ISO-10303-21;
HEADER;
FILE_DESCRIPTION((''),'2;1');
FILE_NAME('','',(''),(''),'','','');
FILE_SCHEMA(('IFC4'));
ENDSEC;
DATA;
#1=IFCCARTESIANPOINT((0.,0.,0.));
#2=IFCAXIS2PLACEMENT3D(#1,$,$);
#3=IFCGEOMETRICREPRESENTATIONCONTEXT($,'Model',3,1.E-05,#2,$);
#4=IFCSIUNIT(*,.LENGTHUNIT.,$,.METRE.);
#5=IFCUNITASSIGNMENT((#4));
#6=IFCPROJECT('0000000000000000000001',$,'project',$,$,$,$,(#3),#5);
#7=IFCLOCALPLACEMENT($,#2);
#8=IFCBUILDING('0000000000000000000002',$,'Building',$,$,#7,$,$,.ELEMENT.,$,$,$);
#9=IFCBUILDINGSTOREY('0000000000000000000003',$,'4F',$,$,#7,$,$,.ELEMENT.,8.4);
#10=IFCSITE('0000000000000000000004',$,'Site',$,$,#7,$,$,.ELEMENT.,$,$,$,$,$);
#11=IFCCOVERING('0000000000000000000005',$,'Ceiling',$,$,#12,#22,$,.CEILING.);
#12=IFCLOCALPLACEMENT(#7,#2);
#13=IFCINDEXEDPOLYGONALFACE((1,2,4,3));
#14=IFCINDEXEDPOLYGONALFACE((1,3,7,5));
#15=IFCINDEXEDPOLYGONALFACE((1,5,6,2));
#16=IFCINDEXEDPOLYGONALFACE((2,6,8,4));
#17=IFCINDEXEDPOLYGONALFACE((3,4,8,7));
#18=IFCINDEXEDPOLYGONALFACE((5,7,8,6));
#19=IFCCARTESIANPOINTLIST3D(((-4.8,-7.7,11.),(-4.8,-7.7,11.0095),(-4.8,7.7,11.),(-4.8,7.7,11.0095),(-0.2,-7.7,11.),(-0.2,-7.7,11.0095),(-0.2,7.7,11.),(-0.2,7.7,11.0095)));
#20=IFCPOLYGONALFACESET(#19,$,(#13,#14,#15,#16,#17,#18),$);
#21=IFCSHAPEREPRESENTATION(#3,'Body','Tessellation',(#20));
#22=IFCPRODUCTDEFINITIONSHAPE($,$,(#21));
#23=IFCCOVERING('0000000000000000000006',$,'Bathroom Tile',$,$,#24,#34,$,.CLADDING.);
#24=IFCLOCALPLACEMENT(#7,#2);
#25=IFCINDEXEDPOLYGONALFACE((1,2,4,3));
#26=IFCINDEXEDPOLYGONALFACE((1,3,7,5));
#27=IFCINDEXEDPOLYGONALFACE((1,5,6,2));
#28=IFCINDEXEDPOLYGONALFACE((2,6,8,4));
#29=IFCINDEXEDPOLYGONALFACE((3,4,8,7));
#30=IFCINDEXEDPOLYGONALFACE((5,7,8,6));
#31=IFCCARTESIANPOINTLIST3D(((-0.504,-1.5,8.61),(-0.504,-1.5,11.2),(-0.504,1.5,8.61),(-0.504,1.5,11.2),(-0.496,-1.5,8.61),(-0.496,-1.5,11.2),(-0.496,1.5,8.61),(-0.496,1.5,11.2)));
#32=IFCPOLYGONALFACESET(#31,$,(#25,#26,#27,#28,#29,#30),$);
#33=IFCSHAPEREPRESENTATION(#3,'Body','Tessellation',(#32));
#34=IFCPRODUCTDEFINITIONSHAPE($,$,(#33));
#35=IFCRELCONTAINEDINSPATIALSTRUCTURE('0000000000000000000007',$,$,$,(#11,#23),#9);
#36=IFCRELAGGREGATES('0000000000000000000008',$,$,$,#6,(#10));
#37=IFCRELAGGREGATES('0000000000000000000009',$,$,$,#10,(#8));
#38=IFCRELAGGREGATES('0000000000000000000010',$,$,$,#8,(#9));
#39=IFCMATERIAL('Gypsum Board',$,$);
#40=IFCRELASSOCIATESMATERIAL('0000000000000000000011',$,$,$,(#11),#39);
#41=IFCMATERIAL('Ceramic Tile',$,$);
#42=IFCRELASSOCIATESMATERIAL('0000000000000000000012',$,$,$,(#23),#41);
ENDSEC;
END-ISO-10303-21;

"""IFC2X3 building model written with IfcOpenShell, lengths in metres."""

from ifc_helpers import new_model, si_unit, frame, origin, origin_2d, place, context, project, spatial, rectangle, extrude, material, element, save


model = new_model("IFC2X3")

# Units and contexts
model_context = context("Model", 3, precision=1e-05, world=origin())
ifc_project = project(units=[si_unit("LENGTHUNIT", "METRE")], contexts=[model_context])

# Site, building, storey
placement = place(None, origin())
site = spatial("IfcSite", under=ifc_project, at=placement, Name="Site", CompositionType="ELEMENT")
building = spatial("IfcBuilding", under=site, at=placement, Name="Building", CompositionType="ELEMENT")
storey = spatial("IfcBuildingStorey", under=building, at=placement, Name="4F", CompositionType="ELEMENT", Elevation=8.4)

# Shared definitions
ifc_material_1 = material(Name="Gypsum Board")

# Coverings
ifc_material_2 = material(Name="Ceramic Tile")
covering_1_placement = place(None, frame((-2.5, 0.0, 11.0)))
element("IfcCovering", 1, at=covering_1_placement, inside=storey, material=ifc_material_1, Name="Ceiling", PredefinedType="CEILING", context=model_context, shape_type="SweptSolid", body=[
    extrude(rectangle(XDim=4.6, YDim=15.4, at=origin_2d()), origin(), (0.0, 0.0, 1.0), 0.0095),
])
covering_2_placement = place(None, frame((-0.5, 0.0, 8.61)))
element("IfcCovering", 2, at=covering_2_placement, inside=storey, material=ifc_material_2, Name="Bathroom Tile", PredefinedType="CLADDING", context=model_context, shape_type="SweptSolid", body=[
    extrude(rectangle(XDim=0.008, YDim=3.0, at=origin_2d()), origin(), (0.0, 0.0, 1.0), 2.59),
])

save(model, "model.ifc")
